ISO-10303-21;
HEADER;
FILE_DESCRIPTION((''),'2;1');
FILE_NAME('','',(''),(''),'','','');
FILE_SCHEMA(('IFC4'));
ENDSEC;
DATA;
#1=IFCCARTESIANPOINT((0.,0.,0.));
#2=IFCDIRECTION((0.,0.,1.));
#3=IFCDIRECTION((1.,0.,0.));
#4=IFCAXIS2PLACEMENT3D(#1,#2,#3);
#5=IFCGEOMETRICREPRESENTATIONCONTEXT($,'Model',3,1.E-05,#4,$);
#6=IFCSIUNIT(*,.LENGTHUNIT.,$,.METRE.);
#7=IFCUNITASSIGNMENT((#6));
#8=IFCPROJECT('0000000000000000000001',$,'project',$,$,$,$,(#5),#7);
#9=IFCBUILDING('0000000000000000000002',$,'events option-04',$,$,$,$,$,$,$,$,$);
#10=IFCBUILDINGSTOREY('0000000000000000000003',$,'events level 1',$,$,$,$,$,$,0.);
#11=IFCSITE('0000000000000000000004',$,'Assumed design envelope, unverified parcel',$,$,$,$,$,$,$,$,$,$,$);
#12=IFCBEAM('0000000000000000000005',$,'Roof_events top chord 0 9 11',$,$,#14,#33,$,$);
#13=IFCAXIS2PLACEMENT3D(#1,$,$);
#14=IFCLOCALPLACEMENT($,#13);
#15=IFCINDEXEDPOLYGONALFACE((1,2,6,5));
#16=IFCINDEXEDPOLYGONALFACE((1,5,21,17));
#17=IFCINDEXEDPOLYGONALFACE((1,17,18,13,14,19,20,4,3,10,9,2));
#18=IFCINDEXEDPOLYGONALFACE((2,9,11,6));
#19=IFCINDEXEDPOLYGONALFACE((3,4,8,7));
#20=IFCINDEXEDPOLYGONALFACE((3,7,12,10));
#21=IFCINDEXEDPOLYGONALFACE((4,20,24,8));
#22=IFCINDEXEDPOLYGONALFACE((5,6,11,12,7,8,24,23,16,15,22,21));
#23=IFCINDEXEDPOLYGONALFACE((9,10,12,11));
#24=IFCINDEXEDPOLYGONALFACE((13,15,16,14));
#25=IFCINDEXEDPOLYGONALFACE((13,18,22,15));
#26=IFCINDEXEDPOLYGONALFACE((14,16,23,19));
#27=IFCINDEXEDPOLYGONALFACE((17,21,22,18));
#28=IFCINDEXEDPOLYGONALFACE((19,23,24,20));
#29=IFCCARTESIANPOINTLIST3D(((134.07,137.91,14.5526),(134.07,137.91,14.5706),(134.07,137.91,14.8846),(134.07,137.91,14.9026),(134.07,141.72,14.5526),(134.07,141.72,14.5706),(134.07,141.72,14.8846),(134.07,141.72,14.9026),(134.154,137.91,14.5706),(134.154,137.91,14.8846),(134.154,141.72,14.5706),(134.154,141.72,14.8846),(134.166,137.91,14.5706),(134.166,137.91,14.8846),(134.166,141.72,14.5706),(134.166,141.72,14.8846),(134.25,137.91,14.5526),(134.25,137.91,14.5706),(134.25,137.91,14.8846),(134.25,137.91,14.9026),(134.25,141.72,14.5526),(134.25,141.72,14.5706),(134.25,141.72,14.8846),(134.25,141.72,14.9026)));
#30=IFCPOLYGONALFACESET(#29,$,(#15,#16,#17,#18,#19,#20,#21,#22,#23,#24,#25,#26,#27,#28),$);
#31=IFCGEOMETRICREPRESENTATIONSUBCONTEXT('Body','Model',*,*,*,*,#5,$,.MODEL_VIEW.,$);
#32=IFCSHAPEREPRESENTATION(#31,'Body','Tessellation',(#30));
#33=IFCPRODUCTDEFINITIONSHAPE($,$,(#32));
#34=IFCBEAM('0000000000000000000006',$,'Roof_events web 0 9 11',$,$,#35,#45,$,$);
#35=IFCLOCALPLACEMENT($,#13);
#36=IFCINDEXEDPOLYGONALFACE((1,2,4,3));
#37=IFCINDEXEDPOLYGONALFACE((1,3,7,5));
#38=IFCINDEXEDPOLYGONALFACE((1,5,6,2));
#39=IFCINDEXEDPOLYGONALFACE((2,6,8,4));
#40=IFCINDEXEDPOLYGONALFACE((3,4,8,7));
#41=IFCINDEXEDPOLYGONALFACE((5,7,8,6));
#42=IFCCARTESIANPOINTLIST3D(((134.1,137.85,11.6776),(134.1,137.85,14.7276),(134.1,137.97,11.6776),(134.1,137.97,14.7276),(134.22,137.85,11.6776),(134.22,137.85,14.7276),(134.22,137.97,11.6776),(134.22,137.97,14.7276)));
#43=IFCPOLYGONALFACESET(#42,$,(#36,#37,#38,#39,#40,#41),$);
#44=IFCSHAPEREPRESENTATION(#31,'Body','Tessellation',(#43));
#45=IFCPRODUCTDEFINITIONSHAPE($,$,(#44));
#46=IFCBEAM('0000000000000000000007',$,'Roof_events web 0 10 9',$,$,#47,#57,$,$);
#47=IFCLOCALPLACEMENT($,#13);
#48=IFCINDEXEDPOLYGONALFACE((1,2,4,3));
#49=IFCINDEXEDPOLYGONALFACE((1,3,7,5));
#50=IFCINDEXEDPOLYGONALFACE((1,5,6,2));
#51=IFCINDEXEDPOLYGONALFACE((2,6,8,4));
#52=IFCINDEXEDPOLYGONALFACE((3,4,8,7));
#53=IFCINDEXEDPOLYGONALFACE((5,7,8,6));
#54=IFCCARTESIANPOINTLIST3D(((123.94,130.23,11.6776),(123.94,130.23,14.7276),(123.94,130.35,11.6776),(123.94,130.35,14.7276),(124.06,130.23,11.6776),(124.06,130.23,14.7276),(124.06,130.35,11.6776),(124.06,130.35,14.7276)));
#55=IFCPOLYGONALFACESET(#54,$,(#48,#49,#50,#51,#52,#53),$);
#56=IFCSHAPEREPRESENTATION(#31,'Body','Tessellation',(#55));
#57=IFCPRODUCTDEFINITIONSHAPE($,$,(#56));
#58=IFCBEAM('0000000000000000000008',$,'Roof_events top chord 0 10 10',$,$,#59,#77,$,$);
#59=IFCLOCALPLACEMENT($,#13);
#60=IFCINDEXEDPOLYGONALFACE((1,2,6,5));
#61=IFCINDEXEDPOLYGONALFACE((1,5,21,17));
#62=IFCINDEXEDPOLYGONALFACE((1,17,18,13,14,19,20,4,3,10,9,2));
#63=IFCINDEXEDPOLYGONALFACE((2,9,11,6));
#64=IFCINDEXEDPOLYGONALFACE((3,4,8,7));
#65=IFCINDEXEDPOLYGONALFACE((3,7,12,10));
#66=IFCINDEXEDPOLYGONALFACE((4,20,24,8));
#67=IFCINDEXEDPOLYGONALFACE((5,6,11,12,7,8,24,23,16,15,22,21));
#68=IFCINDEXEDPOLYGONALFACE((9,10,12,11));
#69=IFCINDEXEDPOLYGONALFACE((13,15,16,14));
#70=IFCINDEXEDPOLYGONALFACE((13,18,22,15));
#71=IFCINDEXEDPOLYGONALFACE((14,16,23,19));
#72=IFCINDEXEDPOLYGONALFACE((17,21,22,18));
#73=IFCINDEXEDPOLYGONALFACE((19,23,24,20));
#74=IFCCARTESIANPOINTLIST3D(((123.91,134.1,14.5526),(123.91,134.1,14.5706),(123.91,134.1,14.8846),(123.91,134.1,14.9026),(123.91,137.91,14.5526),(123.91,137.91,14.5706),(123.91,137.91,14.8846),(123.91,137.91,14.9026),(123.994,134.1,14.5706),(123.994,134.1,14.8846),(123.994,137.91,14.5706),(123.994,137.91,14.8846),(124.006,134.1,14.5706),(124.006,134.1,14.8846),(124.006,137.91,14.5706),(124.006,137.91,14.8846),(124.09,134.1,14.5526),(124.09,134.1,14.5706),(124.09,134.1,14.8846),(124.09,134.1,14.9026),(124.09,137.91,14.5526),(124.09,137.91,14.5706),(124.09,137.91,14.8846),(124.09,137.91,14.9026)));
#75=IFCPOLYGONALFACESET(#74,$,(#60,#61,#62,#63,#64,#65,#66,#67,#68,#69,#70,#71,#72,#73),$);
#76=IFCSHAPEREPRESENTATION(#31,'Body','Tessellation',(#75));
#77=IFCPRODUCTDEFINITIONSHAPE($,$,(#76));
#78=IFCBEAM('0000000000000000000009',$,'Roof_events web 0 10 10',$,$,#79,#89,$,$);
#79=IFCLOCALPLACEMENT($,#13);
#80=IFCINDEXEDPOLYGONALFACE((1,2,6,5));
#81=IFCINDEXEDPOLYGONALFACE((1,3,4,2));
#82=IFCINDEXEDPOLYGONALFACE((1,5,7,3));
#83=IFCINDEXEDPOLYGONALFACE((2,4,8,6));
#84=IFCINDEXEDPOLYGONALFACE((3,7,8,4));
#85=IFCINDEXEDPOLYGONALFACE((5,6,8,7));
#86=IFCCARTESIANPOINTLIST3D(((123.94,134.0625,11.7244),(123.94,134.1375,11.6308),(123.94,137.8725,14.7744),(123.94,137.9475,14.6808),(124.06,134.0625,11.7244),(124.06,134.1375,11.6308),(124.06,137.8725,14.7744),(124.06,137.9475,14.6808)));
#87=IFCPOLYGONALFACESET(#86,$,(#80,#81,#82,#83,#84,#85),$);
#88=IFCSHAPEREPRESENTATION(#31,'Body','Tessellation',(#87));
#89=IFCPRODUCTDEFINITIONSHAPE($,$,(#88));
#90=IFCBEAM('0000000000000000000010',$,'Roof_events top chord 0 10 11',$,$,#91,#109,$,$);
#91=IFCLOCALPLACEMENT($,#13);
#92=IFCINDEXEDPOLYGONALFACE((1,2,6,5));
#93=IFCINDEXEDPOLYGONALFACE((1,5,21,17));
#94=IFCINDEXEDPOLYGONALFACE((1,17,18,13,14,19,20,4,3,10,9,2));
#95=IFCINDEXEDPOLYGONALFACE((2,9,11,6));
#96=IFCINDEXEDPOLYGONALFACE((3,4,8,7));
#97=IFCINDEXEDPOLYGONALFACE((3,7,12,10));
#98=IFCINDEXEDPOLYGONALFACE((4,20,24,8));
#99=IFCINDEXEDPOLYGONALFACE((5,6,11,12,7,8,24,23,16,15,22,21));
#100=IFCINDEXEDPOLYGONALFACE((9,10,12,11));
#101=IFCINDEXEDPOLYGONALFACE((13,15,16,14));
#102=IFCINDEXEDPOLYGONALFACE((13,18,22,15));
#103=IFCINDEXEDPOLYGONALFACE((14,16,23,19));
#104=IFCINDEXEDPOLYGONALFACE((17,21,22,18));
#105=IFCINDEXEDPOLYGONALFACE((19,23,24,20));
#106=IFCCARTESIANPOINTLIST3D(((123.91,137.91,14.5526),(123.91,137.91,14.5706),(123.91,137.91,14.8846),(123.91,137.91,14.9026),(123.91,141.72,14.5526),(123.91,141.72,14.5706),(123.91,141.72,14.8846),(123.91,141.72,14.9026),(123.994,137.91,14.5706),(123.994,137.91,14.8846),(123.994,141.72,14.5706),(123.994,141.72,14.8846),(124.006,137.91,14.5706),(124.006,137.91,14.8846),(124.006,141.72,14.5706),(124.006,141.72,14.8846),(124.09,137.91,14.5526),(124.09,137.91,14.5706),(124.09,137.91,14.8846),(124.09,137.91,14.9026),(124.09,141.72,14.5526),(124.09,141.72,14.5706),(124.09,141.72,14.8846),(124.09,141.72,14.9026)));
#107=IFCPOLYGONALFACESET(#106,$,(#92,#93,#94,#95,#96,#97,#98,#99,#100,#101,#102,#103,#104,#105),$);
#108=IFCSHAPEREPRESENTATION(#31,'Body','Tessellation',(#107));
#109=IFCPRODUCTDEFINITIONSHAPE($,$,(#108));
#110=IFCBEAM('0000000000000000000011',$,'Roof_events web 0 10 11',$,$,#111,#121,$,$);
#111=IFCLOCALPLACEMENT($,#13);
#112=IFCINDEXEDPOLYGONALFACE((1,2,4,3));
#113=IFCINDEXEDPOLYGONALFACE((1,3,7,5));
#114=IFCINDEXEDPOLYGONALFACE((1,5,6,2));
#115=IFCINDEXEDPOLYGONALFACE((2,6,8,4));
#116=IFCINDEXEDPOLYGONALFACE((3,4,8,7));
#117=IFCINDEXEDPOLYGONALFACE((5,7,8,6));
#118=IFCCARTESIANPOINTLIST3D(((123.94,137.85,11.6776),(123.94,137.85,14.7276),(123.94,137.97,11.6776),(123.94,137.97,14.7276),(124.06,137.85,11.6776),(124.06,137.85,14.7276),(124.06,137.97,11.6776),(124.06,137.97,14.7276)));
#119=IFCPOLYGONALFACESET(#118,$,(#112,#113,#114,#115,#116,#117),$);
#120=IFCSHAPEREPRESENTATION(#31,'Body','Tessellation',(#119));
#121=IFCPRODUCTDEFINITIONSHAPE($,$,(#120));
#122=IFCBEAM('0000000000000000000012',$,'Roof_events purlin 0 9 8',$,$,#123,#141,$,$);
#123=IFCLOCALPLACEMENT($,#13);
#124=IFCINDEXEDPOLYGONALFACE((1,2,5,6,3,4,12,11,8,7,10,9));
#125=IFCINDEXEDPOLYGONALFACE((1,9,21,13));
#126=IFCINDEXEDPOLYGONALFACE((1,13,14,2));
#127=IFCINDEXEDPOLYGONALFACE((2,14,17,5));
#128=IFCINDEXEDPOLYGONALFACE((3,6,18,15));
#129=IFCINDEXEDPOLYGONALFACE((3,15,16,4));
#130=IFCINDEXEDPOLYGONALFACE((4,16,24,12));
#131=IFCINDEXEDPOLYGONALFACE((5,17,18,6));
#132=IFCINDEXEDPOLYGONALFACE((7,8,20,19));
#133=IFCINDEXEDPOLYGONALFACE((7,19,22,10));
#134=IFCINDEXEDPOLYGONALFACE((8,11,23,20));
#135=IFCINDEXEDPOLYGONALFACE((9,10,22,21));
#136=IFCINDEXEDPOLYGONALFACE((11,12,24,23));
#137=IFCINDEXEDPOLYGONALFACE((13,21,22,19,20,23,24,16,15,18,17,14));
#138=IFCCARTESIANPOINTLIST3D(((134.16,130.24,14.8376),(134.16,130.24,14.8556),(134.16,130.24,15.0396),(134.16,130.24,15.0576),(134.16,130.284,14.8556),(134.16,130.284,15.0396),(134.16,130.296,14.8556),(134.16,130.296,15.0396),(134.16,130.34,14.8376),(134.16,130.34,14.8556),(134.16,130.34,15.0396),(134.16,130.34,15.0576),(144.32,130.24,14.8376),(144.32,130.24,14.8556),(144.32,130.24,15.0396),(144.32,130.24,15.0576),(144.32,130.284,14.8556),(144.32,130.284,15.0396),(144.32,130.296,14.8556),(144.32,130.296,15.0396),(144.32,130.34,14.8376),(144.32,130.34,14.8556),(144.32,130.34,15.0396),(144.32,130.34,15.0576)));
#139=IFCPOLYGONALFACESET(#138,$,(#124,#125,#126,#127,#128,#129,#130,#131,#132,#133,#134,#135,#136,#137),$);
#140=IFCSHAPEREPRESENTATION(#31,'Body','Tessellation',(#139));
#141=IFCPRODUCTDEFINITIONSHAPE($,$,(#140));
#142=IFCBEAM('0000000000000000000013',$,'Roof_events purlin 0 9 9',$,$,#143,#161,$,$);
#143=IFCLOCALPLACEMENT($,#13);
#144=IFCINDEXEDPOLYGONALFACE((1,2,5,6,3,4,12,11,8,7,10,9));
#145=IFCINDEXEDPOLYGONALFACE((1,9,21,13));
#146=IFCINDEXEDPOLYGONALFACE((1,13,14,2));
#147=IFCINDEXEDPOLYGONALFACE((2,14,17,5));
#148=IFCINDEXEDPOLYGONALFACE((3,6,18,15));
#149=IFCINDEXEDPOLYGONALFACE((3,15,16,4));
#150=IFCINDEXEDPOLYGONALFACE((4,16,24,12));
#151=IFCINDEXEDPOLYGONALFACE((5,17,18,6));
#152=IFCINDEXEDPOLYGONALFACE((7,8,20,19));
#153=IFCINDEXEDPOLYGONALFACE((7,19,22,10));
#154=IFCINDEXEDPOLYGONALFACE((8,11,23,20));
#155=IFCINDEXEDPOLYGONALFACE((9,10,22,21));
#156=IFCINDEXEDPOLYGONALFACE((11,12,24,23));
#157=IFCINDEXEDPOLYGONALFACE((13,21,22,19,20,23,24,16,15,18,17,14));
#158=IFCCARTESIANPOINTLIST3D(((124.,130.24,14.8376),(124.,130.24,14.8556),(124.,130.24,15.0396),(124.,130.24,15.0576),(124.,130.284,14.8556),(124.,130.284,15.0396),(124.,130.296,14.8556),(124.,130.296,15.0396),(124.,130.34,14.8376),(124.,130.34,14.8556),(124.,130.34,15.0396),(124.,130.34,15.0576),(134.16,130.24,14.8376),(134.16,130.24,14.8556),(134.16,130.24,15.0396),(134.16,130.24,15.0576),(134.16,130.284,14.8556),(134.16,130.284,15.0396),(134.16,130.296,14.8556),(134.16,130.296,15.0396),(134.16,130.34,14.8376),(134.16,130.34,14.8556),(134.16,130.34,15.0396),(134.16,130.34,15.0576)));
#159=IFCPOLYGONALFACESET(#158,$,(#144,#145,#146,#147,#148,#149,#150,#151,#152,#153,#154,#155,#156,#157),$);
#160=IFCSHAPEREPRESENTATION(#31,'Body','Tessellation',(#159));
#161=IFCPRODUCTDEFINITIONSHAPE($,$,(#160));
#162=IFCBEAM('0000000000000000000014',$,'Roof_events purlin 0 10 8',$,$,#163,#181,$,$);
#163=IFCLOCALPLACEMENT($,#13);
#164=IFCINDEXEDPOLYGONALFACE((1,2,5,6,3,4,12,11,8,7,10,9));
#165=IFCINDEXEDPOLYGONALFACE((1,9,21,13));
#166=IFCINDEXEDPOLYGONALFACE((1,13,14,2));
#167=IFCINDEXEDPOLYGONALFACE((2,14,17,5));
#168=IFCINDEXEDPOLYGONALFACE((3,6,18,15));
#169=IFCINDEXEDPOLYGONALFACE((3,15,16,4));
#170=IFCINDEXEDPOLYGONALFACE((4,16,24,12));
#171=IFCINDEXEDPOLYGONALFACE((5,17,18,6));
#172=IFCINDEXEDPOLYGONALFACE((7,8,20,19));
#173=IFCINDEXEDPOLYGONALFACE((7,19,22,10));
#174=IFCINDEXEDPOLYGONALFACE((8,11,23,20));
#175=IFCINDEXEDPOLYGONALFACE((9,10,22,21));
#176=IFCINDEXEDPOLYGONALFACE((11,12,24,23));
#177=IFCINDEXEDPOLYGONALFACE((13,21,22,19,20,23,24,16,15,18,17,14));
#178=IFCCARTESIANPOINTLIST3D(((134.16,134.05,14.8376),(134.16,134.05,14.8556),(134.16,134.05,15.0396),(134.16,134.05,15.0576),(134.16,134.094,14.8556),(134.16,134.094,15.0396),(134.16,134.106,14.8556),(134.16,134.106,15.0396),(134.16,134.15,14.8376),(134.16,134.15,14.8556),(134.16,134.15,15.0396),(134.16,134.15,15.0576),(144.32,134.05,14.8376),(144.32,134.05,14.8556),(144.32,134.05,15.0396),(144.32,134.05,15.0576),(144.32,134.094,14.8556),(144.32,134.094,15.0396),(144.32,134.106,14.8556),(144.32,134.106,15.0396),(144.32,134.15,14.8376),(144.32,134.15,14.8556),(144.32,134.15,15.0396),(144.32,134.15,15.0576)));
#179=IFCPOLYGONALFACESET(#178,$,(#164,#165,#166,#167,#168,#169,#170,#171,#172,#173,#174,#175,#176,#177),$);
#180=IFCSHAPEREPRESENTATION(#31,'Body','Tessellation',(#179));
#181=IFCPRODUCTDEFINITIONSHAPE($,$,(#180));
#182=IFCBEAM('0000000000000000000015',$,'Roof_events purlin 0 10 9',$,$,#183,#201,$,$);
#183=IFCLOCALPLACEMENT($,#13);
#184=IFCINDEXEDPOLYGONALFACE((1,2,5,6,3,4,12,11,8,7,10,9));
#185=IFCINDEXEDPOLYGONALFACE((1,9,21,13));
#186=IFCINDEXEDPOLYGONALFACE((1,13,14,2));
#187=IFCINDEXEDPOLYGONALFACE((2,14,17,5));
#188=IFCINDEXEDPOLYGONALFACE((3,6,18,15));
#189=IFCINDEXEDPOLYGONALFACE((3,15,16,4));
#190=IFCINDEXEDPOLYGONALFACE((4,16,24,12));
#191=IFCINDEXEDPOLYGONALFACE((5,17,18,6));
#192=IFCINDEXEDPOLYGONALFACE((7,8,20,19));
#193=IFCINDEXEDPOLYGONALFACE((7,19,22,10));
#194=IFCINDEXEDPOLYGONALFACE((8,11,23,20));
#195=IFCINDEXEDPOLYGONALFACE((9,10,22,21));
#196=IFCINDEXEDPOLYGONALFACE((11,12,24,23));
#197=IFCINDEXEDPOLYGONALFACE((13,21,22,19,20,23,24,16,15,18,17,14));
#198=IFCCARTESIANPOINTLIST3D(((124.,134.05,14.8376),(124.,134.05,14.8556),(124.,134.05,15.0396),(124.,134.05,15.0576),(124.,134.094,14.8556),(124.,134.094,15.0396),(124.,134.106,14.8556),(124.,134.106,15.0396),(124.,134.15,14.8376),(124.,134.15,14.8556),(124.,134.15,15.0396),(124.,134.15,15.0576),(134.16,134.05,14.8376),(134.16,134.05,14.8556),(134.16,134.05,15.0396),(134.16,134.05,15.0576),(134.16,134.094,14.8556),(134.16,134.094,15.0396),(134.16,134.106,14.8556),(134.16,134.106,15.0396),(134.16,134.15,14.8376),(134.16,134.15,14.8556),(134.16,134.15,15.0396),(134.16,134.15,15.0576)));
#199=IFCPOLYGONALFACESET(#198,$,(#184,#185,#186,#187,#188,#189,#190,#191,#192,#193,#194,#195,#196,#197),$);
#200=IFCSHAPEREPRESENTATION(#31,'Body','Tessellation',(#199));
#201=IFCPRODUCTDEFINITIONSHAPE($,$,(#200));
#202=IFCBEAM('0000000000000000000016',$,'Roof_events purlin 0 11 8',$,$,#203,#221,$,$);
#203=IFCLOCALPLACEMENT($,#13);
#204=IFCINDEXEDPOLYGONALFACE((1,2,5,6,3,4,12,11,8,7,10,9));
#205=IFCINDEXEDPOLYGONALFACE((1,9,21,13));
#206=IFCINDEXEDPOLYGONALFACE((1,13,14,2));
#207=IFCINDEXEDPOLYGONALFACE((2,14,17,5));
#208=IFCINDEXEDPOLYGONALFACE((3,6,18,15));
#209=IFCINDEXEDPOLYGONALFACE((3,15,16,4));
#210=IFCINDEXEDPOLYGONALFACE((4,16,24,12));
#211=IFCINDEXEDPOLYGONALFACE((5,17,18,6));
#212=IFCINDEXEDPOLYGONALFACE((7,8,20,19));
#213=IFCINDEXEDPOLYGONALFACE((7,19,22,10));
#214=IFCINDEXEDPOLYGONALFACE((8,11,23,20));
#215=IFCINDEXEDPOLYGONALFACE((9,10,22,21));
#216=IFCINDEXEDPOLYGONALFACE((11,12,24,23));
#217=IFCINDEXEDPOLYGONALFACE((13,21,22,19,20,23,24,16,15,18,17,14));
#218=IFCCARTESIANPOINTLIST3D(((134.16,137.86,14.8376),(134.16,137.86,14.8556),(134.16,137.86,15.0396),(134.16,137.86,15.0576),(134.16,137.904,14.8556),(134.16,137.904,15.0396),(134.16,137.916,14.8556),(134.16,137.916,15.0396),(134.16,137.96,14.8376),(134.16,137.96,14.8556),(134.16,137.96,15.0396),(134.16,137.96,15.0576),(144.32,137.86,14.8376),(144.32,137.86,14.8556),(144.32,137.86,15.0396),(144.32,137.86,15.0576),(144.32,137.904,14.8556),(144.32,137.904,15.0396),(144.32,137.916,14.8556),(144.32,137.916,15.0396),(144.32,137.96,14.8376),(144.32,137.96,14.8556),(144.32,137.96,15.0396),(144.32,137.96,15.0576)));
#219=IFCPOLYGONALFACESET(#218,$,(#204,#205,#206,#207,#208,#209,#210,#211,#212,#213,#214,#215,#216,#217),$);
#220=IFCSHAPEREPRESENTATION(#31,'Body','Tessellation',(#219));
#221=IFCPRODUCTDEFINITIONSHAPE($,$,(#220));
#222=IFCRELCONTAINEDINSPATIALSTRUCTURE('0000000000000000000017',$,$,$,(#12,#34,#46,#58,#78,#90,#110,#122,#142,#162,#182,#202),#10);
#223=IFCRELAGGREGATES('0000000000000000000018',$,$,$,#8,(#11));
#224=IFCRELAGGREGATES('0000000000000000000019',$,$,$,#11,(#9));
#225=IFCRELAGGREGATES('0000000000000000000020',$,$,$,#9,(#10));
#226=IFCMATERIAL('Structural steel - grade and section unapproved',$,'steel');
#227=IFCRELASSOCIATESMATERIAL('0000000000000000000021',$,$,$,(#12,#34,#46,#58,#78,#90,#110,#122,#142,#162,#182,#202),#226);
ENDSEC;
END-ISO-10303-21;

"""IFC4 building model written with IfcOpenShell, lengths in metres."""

from ifc_helpers import new_model, si_unit, frame, origin_with_axes, place, context, subcontext, project, spatial, rectangle, i_section, extrude, material, element, save


model = new_model("IFC4")

# Units and contexts
model_context = context("Model", 3, precision=1e-05, world=origin_with_axes())
body_context = subcontext(model_context, "Body", "Model", "MODEL_VIEW")
ifc_project = project(units=[si_unit("LENGTHUNIT", "METRE")], contexts=[model_context])

# Site, building, storey
site = spatial("IfcSite", under=ifc_project, Name="Assumed design envelope, unverified parcel")
building = spatial("IfcBuilding", under=site, Name="events option-04")
storey = spatial("IfcBuildingStorey", under=building, Name="events level 1", Elevation=0.0)

# Shared definitions
ifc_material = material(Name="Structural steel - grade and section unapproved", Category="steel")

# Beams
beam_1_placement = place(None, frame((134.16, 137.91, 14.7276), z_axis=(0.0, 1.0, 0.0), x_axis=(-1.0, 0.0, 0.0)))
element("IfcBeam", 1, at=beam_1_placement, inside=storey, material=ifc_material, Name="Roof_events top chord 0 9 11", context=body_context, shape_type="SweptSolid", body=[
    extrude(i_section(OverallWidth=0.18, OverallDepth=0.35, WebThickness=0.012, FlangeThickness=0.018, FilletRadius=0.0), origin_with_axes(), (0.0, 0.0, 1.0), 3.81),
])
for number, where, z_axis, x_axis, name in (
    (2, (134.16, 137.91, 11.6776), (0.0, 0.0, 1.0), (-1.0, 0.0, 0.0), "Roof_events web 0 9 11"),
    (3, (124.0, 130.29, 11.6776), (0.0, 0.0, 1.0), (-1.0, 0.0, 0.0), "Roof_events web 0 10 9"),
):
    element("IfcBeam", number, at=place(None, frame(where, z_axis=z_axis, x_axis=x_axis)), inside=storey, material=ifc_material, Name=name, context=body_context, shape_type="SweptSolid", body=[
        extrude(rectangle(XDim=0.12, YDim=0.12), origin_with_axes(), (0.0, 0.0, 1.0), 3.05),
    ])
beam_2_placement = place(None, frame((124.0, 134.1, 14.7276), z_axis=(0.0, 1.0, 0.0), x_axis=(-1.0, 0.0, 0.0)))
element("IfcBeam", 4, at=beam_2_placement, inside=storey, material=ifc_material, Name="Roof_events top chord 0 10 10", context=body_context, shape_type="SweptSolid", body=[
    extrude(i_section(OverallWidth=0.18, OverallDepth=0.35, WebThickness=0.012, FlangeThickness=0.018, FilletRadius=0.0), origin_with_axes(), (0.0, 0.0, 1.0), 3.81),
])
beam_3_placement = place(None, frame((124.0, 134.1, 11.6776), z_axis=(0.0, 0.780669, 0.624945), x_axis=(-1.0, 0.0, 0.0)))
element("IfcBeam", 5, at=beam_3_placement, inside=storey, material=ifc_material, Name="Roof_events web 0 10 10", context=body_context, shape_type="SweptSolid", body=[
    extrude(rectangle(XDim=0.12, YDim=0.12), origin_with_axes(), (0.0, 0.0, 1.0), 4.8804),
])
beam_4_placement = place(None, frame((124.0, 137.91, 14.7276), z_axis=(0.0, 1.0, 0.0), x_axis=(-1.0, 0.0, 0.0)))
element("IfcBeam", 6, at=beam_4_placement, inside=storey, material=ifc_material, Name="Roof_events top chord 0 10 11", context=body_context, shape_type="SweptSolid", body=[
    extrude(i_section(OverallWidth=0.18, OverallDepth=0.35, WebThickness=0.012, FlangeThickness=0.018, FilletRadius=0.0), origin_with_axes(), (0.0, 0.0, 1.0), 3.81),
])
beam_5_placement = place(None, frame((124.0, 137.91, 11.6776), z_axis=(0.0, 0.0, 1.0), x_axis=(-1.0, 0.0, 0.0)))
element("IfcBeam", 7, at=beam_5_placement, inside=storey, material=ifc_material, Name="Roof_events web 0 10 11", context=body_context, shape_type="SweptSolid", body=[
    extrude(rectangle(XDim=0.12, YDim=0.12), origin_with_axes(), (0.0, 0.0, 1.0), 3.05),
])
for number, where, z_axis, x_axis, name in (
    (8, (144.32, 130.29, 14.9476), (-1.0, 0.0, 0.0), (0.0, -1.0, 0.0), "Roof_events purlin 0 9 8"),
    (9, (134.16, 130.29, 14.9476), (-1.0, 0.0, 0.0), (0.0, -1.0, 0.0), "Roof_events purlin 0 9 9"),
    (10, (144.32, 134.1, 14.9476), (-1.0, 0.0, 0.0), (0.0, -1.0, 0.0), "Roof_events purlin 0 10 8"),
    (11, (134.16, 134.1, 14.9476), (-1.0, 0.0, 0.0), (0.0, -1.0, 0.0), "Roof_events purlin 0 10 9"),
    (12, (144.32, 137.91, 14.9476), (-1.0, 0.0, 0.0), (0.0, -1.0, 0.0), "Roof_events purlin 0 11 8"),
):
    element("IfcBeam", number, at=place(None, frame(where, z_axis=z_axis, x_axis=x_axis)), inside=storey, material=ifc_material, Name=name, context=body_context, shape_type="SweptSolid", body=[
        extrude(i_section(OverallWidth=0.1, OverallDepth=0.22, WebThickness=0.012, FlangeThickness=0.018, FilletRadius=0.0), origin_with_axes(), (0.0, 0.0, 1.0), 10.16),
    ])

save(model, "model.ifc")
